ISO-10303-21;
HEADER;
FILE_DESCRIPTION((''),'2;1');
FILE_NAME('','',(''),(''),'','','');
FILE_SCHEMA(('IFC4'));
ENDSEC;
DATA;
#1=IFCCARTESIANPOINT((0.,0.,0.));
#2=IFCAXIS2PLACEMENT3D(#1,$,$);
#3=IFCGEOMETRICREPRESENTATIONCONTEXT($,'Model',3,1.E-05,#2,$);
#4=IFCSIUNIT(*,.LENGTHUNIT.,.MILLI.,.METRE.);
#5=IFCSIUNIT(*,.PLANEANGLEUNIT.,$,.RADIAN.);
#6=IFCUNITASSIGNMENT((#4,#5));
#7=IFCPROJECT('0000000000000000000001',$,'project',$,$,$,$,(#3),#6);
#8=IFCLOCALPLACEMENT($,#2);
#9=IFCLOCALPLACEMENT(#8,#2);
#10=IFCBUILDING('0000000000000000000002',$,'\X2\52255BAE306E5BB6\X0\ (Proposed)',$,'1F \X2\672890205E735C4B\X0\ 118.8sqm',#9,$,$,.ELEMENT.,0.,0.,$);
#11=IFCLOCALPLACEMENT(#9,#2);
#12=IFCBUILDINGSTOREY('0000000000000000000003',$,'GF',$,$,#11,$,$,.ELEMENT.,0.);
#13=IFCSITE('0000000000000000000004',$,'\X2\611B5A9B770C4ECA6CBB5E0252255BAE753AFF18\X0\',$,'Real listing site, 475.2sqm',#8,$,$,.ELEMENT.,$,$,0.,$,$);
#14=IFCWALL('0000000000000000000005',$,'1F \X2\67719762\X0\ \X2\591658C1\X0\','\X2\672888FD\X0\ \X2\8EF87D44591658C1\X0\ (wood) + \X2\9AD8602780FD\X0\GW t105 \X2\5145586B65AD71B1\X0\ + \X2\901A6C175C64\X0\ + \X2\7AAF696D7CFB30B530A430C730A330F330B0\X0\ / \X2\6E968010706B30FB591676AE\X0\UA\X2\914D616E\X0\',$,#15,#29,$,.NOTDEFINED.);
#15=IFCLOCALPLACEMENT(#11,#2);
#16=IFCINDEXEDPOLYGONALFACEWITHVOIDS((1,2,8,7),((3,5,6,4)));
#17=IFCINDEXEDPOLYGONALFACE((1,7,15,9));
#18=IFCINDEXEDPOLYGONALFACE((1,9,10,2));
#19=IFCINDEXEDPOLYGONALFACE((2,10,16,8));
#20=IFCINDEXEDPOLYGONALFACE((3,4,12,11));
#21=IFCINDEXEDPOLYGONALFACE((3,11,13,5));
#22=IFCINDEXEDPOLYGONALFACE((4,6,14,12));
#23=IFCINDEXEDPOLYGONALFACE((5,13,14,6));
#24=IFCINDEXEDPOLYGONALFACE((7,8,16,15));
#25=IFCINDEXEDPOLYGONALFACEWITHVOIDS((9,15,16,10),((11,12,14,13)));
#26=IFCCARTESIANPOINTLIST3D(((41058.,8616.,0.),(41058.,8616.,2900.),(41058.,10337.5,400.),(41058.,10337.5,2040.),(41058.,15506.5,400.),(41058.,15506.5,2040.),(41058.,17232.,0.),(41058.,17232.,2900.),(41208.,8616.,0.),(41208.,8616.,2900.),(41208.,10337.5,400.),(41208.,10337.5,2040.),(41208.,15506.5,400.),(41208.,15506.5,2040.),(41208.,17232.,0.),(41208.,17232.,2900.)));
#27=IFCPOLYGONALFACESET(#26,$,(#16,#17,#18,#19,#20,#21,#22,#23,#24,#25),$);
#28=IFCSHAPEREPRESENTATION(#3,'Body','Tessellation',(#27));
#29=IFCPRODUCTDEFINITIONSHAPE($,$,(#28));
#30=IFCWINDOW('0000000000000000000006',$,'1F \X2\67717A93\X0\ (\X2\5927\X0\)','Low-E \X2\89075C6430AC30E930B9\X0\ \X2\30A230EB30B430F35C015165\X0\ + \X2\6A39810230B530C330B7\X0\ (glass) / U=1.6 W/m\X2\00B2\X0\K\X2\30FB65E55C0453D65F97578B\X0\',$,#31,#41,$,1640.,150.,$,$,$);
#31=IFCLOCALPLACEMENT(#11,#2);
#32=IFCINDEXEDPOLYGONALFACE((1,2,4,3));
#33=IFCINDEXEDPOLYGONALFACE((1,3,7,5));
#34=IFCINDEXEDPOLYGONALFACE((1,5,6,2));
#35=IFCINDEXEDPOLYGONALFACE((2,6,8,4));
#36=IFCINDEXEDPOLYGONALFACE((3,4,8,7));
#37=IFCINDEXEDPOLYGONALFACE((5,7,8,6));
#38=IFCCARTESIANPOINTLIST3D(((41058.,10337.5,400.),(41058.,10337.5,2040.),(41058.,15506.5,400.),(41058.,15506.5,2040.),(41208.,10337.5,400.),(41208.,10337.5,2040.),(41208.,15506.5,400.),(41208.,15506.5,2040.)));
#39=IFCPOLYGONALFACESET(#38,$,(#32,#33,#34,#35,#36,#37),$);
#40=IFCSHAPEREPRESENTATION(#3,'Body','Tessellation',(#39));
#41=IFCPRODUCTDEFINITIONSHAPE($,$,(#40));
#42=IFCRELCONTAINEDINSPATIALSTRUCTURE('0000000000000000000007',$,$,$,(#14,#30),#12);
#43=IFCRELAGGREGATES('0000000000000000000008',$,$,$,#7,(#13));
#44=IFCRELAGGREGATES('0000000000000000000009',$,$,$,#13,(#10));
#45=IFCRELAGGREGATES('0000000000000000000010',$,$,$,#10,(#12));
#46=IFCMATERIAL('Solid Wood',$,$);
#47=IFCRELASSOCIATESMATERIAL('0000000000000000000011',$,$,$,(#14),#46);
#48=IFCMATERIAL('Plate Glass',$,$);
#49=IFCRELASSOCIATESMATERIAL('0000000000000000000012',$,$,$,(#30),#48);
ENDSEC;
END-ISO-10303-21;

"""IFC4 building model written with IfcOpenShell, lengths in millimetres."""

from ifc_helpers import new_model, si_unit, frame, frame_2d, origin, place, context, project, spatial, rectangle, extrude, material, element, fill, save


model = new_model("IFC4")

# Units and contexts
model_context = context("Model", 3, precision=1e-05, world=origin())
ifc_project = project(units=[si_unit("LENGTHUNIT", "METRE", prefix="MILLI"), si_unit("PLANEANGLEUNIT", "RADIAN")], contexts=[model_context])

# Site, building, storey
site_placement = place(None, origin())
site = spatial("IfcSite", under=ifc_project, at=site_placement, Name="愛媛県今治市別宮町８", ObjectType="Real listing site, 475.2sqm", CompositionType="ELEMENT", RefElevation=0.0)
building_placement = place(site_placement, origin())
building = spatial("IfcBuilding", under=site, at=building_placement, Name="別宮の家 (Proposed)", ObjectType="1F 木造平屋 118.8sqm", CompositionType="ELEMENT", ElevationOfRefHeight=0.0, ElevationOfTerrain=0.0)
storey_placement = place(building_placement, origin())
storey = spatial("IfcBuildingStorey", under=building, at=storey_placement, Name="GF", CompositionType="ELEMENT", Elevation=0.0)

# Wall, opening, window
ifc_material_1 = material(Name="Solid Wood")
wall_1_placement = place(storey_placement, frame((20529.0, 4308.0, 0.0)))
wall_1 = element("IfcWall", 1, at=wall_1_placement, inside=storey, material=ifc_material_1, Name="1F 東面 外壁", Description="木製 軸組外壁 (wood) + 高性能GW t105 充填断熱 + 通気層 + 窯業系サイディング / 準耐火・外皮UA配慮", PredefinedType="NOTDEFINED", context=model_context, shape_type="SweptSolid", body=[
    extrude(rectangle(XDim=150.0, YDim=8616.0, at=frame_2d((75.0, 4308.0))), frame((20529.0, 4308.0, 0.0)), (0.0, 0.0, 1.0), 2900.0),
])
opening_1_placement = place(storey_placement, frame((20529.0, 5169.0, 200.0)))
opening_1 = element("IfcOpeningElement", 2, at=opening_1_placement, cuts=wall_1, PredefinedType="NOTDEFINED", context=model_context, shape_type="SweptSolid", body=[
    extrude(rectangle(XDim=150.0, YDim=5169.0, at=frame_2d((75.0, 2584.0))), frame((20529.0, 5169.0, 200.0)), (0.0, 0.0, 1.0), 1640.0),
])
ifc_material_2 = material(Name="Plate Glass")
window_1_placement = place(storey_placement, frame((20529.0, 5169.0, 200.0)))
window_1 = element("IfcWindow", 3, at=window_1_placement, inside=storey, material=ifc_material_2, Name="1F 東窓 (大)", Description="Low-E 複層ガラス アルゴン封入 + 樹脂サッシ (glass) / U=1.6 W/m²K・日射取得型", OverallHeight=1640.0, OverallWidth=150.0, context=model_context, shape_type="SweptSolid", body=[
    extrude(rectangle(XDim=150.0, YDim=5169.0, at=frame_2d((75.0, 2584.0))), frame((20529.0, 5169.0, 200.0)), (0.0, 0.0, 1.0), 1640.0),
])
fill(opening_1, window_1)

save(model, "model.ifc")
